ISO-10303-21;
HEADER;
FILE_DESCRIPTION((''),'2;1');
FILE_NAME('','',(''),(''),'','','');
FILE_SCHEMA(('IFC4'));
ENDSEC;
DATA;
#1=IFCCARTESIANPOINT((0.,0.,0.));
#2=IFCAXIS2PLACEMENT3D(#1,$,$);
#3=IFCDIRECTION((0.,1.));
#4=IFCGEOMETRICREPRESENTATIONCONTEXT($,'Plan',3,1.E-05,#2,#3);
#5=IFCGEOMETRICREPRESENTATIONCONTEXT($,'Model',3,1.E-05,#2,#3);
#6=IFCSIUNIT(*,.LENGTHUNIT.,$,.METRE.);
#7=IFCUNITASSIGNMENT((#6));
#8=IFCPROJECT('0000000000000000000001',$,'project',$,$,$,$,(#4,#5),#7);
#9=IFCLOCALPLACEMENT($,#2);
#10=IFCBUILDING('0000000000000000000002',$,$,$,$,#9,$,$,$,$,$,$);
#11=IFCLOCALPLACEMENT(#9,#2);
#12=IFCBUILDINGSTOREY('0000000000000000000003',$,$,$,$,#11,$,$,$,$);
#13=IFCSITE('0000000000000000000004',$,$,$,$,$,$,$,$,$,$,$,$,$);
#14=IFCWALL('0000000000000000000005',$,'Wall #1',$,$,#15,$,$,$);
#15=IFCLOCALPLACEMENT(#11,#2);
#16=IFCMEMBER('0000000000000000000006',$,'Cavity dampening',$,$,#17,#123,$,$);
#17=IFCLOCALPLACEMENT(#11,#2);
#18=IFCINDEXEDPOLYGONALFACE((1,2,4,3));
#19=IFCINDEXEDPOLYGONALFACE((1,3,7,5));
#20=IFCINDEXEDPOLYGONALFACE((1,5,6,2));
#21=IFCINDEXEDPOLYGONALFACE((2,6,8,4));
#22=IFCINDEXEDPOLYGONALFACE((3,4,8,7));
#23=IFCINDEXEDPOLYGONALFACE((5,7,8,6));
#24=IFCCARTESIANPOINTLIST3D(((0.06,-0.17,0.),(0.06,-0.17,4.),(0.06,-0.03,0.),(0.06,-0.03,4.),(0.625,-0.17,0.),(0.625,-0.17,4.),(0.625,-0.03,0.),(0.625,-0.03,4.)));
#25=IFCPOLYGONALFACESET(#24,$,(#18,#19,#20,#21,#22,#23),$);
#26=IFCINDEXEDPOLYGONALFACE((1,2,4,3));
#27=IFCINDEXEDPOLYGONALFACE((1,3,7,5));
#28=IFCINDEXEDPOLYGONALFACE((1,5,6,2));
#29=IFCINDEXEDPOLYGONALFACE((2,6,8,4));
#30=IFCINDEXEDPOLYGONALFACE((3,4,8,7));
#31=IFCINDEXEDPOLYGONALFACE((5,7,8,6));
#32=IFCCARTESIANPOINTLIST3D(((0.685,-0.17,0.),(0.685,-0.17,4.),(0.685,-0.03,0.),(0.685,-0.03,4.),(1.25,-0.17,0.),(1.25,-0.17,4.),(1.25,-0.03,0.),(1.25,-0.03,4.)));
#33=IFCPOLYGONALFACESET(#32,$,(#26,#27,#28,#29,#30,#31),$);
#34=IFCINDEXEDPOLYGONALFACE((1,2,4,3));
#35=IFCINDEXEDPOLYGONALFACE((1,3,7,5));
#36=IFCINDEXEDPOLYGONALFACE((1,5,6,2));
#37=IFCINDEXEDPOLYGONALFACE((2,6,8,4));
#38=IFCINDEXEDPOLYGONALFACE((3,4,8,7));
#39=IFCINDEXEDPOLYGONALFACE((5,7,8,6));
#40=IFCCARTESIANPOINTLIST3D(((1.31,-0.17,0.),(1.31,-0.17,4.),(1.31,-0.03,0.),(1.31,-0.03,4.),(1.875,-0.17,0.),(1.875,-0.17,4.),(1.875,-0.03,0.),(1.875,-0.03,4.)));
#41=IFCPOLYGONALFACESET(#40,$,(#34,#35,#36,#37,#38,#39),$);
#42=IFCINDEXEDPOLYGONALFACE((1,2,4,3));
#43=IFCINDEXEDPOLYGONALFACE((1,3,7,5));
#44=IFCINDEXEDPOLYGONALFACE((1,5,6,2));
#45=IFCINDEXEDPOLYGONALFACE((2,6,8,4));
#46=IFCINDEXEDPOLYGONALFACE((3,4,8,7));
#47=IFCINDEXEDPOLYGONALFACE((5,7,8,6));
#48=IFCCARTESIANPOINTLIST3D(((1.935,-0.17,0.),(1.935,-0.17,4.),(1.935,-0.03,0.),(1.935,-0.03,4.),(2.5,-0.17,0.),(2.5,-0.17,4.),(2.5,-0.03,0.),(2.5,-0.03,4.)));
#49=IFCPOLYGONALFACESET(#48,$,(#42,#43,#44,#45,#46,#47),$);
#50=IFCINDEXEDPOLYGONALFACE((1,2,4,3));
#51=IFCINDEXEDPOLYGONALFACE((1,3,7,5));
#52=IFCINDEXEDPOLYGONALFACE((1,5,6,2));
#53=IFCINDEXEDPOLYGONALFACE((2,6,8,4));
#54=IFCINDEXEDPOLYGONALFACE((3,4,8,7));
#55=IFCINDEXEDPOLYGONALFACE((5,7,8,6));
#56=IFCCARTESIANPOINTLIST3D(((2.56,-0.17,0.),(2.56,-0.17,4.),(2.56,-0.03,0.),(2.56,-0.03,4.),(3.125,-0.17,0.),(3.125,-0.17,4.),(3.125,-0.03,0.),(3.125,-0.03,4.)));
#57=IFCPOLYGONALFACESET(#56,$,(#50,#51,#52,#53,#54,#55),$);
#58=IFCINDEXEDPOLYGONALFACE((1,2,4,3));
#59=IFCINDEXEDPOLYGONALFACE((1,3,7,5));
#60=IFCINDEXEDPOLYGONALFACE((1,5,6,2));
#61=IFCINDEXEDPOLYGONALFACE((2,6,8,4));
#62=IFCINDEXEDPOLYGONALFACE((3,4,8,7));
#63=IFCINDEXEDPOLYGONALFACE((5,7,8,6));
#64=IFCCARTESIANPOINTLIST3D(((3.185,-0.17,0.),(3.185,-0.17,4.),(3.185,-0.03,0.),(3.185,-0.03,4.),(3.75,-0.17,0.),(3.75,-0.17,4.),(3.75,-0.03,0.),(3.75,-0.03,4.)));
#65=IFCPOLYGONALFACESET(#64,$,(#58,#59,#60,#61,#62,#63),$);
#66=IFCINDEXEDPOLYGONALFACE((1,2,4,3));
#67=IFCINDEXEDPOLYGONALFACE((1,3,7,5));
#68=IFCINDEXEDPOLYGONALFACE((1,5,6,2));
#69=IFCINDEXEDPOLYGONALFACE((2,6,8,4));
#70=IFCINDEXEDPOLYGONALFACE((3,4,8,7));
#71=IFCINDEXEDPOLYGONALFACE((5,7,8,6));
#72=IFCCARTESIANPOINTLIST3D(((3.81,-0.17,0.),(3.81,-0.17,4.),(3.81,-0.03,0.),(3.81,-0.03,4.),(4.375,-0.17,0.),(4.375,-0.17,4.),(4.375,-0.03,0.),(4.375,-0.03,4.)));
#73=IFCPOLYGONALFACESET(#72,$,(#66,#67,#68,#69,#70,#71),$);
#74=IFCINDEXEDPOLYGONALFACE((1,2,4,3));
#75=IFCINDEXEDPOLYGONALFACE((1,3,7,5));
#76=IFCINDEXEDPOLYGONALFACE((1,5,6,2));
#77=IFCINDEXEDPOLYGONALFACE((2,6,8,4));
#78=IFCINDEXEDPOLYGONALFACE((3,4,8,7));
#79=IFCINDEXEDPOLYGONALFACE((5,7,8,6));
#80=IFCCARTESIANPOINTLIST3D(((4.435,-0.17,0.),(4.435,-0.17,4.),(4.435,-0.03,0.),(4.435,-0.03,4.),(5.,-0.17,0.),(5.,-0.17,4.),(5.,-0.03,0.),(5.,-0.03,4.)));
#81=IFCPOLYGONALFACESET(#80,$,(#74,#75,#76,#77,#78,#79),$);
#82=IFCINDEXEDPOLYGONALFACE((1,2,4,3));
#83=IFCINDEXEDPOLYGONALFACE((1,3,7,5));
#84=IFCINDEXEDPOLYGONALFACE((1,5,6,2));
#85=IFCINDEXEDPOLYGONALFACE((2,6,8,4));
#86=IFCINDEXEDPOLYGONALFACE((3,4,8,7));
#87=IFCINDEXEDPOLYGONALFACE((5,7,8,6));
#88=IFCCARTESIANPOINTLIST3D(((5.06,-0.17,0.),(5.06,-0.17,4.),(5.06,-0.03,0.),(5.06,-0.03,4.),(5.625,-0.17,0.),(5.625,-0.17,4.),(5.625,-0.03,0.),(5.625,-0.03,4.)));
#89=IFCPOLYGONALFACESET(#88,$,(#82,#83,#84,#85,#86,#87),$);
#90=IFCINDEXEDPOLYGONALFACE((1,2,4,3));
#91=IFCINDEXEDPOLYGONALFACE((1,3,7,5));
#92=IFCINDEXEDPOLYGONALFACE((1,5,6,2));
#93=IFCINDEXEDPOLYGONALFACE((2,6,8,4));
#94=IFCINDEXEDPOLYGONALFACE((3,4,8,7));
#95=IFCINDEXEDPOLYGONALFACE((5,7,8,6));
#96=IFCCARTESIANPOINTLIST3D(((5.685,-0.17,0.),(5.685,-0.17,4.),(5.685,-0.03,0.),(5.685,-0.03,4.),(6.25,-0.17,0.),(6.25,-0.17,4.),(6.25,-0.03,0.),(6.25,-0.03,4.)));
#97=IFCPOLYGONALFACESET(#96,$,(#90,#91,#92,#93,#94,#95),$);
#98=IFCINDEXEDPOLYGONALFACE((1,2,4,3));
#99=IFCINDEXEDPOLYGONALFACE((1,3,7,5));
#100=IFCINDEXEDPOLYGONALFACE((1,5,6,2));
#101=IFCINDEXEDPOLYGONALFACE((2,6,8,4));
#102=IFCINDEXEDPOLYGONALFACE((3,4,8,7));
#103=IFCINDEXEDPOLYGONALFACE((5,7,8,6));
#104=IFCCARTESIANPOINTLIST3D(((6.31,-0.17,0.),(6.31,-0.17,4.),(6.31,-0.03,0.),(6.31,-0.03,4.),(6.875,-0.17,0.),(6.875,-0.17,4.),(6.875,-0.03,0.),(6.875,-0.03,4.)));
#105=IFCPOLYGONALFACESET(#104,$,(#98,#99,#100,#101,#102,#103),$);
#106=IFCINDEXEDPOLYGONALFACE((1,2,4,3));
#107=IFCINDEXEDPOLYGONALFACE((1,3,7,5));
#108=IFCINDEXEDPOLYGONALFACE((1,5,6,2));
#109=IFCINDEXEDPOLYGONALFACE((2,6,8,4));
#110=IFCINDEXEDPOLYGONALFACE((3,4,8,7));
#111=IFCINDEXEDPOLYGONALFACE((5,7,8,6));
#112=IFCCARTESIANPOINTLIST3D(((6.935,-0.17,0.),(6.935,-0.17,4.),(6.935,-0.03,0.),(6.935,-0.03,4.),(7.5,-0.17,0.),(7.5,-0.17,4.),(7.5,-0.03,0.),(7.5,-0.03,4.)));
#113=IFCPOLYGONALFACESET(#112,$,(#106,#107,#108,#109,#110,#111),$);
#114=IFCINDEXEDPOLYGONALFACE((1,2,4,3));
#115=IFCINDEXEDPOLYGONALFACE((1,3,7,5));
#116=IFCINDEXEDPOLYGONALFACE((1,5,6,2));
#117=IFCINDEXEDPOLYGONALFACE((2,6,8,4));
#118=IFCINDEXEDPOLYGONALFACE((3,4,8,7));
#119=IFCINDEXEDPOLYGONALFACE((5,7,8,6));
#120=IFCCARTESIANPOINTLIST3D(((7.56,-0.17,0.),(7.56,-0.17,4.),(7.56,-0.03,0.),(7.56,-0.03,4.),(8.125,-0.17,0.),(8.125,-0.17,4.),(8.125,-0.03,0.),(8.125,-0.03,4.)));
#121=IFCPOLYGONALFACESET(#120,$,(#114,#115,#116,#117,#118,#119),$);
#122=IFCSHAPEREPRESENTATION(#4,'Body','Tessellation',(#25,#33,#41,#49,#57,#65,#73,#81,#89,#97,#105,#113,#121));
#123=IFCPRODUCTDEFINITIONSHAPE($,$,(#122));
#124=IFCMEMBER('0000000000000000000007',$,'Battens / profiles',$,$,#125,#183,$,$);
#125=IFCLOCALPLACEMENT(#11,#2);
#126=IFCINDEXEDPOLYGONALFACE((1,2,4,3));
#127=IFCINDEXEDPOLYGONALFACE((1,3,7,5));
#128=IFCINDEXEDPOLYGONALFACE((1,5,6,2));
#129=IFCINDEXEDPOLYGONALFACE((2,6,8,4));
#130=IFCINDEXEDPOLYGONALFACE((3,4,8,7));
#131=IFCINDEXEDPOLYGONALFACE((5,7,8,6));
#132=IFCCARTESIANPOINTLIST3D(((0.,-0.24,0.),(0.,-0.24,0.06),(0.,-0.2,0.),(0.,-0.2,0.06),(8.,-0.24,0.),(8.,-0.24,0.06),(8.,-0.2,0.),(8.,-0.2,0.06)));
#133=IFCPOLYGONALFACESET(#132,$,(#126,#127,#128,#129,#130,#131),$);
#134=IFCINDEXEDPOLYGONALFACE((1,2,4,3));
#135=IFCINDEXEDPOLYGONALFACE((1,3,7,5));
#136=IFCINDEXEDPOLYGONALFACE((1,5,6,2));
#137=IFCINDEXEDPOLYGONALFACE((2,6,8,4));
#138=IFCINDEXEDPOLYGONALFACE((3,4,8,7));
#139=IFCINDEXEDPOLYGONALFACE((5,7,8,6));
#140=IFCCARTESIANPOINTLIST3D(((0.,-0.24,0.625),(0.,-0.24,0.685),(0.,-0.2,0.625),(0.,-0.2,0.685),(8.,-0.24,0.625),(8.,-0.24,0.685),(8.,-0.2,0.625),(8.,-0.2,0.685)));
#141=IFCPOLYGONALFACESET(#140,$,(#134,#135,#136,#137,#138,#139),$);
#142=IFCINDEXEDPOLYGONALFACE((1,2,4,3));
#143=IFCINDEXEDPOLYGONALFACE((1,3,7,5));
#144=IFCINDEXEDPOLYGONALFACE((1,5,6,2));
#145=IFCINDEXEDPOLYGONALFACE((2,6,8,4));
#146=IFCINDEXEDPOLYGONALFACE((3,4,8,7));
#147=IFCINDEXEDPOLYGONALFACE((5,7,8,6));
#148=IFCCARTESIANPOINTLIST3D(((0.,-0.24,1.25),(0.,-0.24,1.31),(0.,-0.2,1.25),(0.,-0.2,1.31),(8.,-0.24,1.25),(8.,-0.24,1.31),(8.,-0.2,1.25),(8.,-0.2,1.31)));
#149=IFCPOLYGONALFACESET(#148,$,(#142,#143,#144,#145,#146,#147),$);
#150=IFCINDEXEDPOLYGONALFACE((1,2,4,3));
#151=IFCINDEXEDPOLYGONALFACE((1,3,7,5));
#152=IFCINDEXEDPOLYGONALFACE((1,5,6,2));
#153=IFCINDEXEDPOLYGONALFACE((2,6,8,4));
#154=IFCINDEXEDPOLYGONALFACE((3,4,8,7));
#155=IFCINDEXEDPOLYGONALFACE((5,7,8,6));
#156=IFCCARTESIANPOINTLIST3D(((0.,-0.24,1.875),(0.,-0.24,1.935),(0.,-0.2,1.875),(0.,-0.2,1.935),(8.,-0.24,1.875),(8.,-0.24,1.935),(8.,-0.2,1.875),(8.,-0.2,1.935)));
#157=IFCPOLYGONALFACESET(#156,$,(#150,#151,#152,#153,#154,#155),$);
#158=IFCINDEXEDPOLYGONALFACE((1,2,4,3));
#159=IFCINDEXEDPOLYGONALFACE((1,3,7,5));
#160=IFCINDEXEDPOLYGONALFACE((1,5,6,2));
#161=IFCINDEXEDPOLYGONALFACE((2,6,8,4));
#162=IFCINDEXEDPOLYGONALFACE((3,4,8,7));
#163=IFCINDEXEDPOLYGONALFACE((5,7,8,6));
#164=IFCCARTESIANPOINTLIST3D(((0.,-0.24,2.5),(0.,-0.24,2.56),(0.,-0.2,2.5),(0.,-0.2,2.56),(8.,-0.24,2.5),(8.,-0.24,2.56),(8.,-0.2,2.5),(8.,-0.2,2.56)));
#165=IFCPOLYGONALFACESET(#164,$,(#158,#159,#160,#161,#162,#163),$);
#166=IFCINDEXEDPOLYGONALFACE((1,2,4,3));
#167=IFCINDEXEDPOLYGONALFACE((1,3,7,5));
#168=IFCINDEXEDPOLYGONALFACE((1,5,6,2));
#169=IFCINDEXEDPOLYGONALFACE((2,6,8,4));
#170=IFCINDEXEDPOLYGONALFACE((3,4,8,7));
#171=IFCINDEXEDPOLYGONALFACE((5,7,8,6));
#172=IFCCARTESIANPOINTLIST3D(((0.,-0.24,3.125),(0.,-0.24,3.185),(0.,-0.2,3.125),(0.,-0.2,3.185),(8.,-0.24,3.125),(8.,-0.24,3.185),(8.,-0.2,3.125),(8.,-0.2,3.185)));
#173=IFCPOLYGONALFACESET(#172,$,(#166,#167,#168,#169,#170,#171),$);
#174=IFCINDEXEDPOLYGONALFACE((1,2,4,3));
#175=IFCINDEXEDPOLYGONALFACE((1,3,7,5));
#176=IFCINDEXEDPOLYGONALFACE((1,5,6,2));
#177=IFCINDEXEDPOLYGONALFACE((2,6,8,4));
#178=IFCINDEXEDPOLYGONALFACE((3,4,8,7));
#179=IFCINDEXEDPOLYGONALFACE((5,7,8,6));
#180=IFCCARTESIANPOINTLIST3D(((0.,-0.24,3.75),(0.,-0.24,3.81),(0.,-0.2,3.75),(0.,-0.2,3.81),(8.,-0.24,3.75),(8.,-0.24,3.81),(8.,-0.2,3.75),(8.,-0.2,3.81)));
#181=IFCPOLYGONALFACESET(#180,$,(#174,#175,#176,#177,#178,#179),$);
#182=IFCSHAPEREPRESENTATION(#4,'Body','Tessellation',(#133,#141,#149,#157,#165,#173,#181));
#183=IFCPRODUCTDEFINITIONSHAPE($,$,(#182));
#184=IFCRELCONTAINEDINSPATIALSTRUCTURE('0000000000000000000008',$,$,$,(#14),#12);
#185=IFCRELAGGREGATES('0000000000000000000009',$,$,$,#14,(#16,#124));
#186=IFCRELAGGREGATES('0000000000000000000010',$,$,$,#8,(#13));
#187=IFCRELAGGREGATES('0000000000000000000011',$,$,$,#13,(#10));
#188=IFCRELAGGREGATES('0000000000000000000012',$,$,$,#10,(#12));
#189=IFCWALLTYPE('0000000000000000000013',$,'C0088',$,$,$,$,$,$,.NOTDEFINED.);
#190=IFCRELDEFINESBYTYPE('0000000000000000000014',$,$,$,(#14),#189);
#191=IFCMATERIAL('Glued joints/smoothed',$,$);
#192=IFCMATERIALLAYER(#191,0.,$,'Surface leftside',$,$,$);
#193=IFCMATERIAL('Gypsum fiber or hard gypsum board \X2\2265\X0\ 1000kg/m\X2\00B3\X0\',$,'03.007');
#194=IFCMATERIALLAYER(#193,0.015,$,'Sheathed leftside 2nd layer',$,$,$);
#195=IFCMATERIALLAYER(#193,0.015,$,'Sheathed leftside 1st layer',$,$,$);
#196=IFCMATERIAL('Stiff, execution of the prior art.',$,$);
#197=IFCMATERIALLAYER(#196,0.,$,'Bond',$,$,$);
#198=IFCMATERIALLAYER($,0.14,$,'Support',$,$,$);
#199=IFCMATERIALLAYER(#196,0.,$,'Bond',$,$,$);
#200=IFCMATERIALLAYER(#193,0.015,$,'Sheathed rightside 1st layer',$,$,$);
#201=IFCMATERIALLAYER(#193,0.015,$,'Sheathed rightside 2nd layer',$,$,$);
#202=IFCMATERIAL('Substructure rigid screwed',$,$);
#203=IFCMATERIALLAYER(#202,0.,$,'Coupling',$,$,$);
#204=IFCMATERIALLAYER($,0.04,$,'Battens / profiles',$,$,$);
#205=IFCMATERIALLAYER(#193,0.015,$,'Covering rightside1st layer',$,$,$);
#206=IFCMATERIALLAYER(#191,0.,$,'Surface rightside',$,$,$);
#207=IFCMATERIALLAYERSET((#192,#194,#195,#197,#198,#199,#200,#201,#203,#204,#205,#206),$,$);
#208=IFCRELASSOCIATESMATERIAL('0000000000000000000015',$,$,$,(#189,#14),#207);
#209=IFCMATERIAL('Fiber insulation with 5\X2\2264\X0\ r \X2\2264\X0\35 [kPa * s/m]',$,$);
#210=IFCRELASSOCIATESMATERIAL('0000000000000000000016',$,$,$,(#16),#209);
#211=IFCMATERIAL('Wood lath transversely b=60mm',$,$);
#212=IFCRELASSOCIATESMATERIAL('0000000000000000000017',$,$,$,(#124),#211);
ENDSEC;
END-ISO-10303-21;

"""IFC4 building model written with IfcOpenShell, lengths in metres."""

from ifc_helpers import new_model, si_unit, direction, frame, frame_2d, origin, place, context, project, spatial, rectangle, extrude, material, layer, layer_set, type_object, element, aggregate, save


model = new_model("IFC4")

# Units and contexts
plan_context = context("Plan", 3, precision=1e-05, world=origin(), true_north=direction((0.0, 1.0)))
model_context = context("Model", 3, precision=1e-05, world=origin(), true_north=direction((0.0, 1.0)))
ifc_project = project(units=[si_unit("LENGTHUNIT", "METRE")], contexts=[plan_context, model_context])

# Site, building, storey
site = spatial("IfcSite", under=ifc_project)
building_placement = place(None, origin())
building = spatial("IfcBuilding", under=site, at=building_placement)
storey_placement = place(building_placement, origin())
storey = spatial("IfcBuildingStorey", under=building, at=storey_placement)

# Wall, members
ifc_material_1 = material(Name="Glued joints/smoothed")
ifc_layer_1 = layer(ifc_material_1, 0.0, Name="Surface leftside")
ifc_material_2 = material(Name="Gypsum fiber or hard gypsum board ≥ 1000kg/m³", Category="03.007")
ifc_layer_2 = layer(ifc_material_2, 0.015, Name="Sheathed leftside 2nd layer")
ifc_layer_3 = layer(ifc_material_2, 0.015, Name="Sheathed leftside 1st layer")
ifc_material_3 = material(Name="Stiff, execution of the prior art.")
ifc_layer_4 = layer(ifc_material_3, 0.0, Name="Bond")
ifc_layer_5 = layer(None, 0.14, Name="Support")
ifc_layer_6 = layer(ifc_material_3, 0.0, Name="Bond")
ifc_layer_7 = layer(ifc_material_2, 0.015, Name="Sheathed rightside 1st layer")
ifc_layer_8 = layer(ifc_material_2, 0.015, Name="Sheathed rightside 2nd layer")
ifc_material_4 = material(Name="Substructure rigid screwed")
ifc_layer_9 = layer(ifc_material_4, 0.0, Name="Coupling")
ifc_layer_10 = layer(None, 0.04, Name="Battens / profiles")
ifc_layer_11 = layer(ifc_material_2, 0.015, Name="Covering rightside1st layer")
ifc_layer_12 = layer(ifc_material_1, 0.0, Name="Surface rightside")
ifc_layer_set = layer_set([ifc_layer_1, ifc_layer_2, ifc_layer_3, ifc_layer_4, ifc_layer_5, ifc_layer_6, ifc_layer_7, ifc_layer_8, ifc_layer_9, ifc_layer_10, ifc_layer_11, ifc_layer_12])
wall_type = type_object("IfcWallType", Name="C0088", PredefinedType="NOTDEFINED", material=ifc_layer_set)
wall_placement = place(None, frame((0.0, 0.0, 0.0), z_axis=(0.0, -1.0, 0.0), x_axis=(1.0, 0.0, 0.0)))
wall = element("IfcWall", 1, at=wall_placement, inside=storey, type_object=wall_type, material=ifc_layer_set, Name="Wall #1")
ifc_material_5 = material(Name="Fiber insulation with 5≤ r ≤35 [kPa * s/m]")
member_1_placement = place(wall_placement, origin())
member_1 = element("IfcMember", 2, at=member_1_placement, material=ifc_material_5, Name="Cavity dampening", context=plan_context, shape_type="SweptSolid", body=[
    extrude(rectangle(XDim=0.565, YDim=0.14, at=frame_2d((0.2825, 0.07), x_axis=(1.0, 0.0))), frame((0.06, 4.0, 0.03), z_axis=(0.0, -1.0, 0.0), x_axis=(1.0, 0.0, 0.0)), (0.0, 0.0, 1.0), 4.0),
    extrude(rectangle(XDim=0.565, YDim=0.14, at=frame_2d((0.2825, 0.07), x_axis=(1.0, 0.0))), frame((0.685, 4.0, 0.03), z_axis=(0.0, -1.0, 0.0), x_axis=(1.0, 0.0, 0.0)), (0.0, 0.0, 1.0), 4.0),
    extrude(rectangle(XDim=0.565, YDim=0.14, at=frame_2d((0.2825, 0.07), x_axis=(1.0, 0.0))), frame((1.31, 4.0, 0.03), z_axis=(0.0, -1.0, 0.0), x_axis=(1.0, 0.0, 0.0)), (0.0, 0.0, 1.0), 4.0),
    extrude(rectangle(XDim=0.565, YDim=0.14, at=frame_2d((0.2825, 0.07), x_axis=(1.0, 0.0))), frame((1.935, 4.0, 0.03), z_axis=(0.0, -1.0, 0.0), x_axis=(1.0, 0.0, 0.0)), (0.0, 0.0, 1.0), 4.0),
    extrude(rectangle(XDim=0.565, YDim=0.14, at=frame_2d((0.2825, 0.07), x_axis=(1.0, 0.0))), frame((2.56, 4.0, 0.03), z_axis=(0.0, -1.0, 0.0), x_axis=(1.0, 0.0, 0.0)), (0.0, 0.0, 1.0), 4.0),
    extrude(rectangle(XDim=0.565, YDim=0.14, at=frame_2d((0.2825, 0.07), x_axis=(1.0, 0.0))), frame((3.185, 4.0, 0.03), z_axis=(0.0, -1.0, 0.0), x_axis=(1.0, 0.0, 0.0)), (0.0, 0.0, 1.0), 4.0),
    extrude(rectangle(XDim=0.565, YDim=0.14, at=frame_2d((0.2825, 0.07), x_axis=(1.0, 0.0))), frame((3.81, 4.0, 0.03), z_axis=(0.0, -1.0, 0.0), x_axis=(1.0, 0.0, 0.0)), (0.0, 0.0, 1.0), 4.0),
    extrude(rectangle(XDim=0.565, YDim=0.14, at=frame_2d((0.2825, 0.07), x_axis=(1.0, 0.0))), frame((4.435, 4.0, 0.03), z_axis=(0.0, -1.0, 0.0), x_axis=(1.0, 0.0, 0.0)), (0.0, 0.0, 1.0), 4.0),
    extrude(rectangle(XDim=0.565, YDim=0.14, at=frame_2d((0.2825, 0.07), x_axis=(1.0, 0.0))), frame((5.06, 4.0, 0.03), z_axis=(0.0, -1.0, 0.0), x_axis=(1.0, 0.0, 0.0)), (0.0, 0.0, 1.0), 4.0),
    extrude(rectangle(XDim=0.565, YDim=0.14, at=frame_2d((0.2825, 0.07), x_axis=(1.0, 0.0))), frame((5.685, 4.0, 0.03), z_axis=(0.0, -1.0, 0.0), x_axis=(1.0, 0.0, 0.0)), (0.0, 0.0, 1.0), 4.0),
    extrude(rectangle(XDim=0.565, YDim=0.14, at=frame_2d((0.2825, 0.07), x_axis=(1.0, 0.0))), frame((6.31, 4.0, 0.03), z_axis=(0.0, -1.0, 0.0), x_axis=(1.0, 0.0, 0.0)), (0.0, 0.0, 1.0), 4.0),
    extrude(rectangle(XDim=0.565, YDim=0.14, at=frame_2d((0.2825, 0.07), x_axis=(1.0, 0.0))), frame((6.935, 4.0, 0.03), z_axis=(0.0, -1.0, 0.0), x_axis=(1.0, 0.0, 0.0)), (0.0, 0.0, 1.0), 4.0),
    extrude(rectangle(XDim=0.565, YDim=0.14, at=frame_2d((0.2825, 0.07), x_axis=(1.0, 0.0))), frame((7.56, 4.0, 0.03), z_axis=(0.0, -1.0, 0.0), x_axis=(1.0, 0.0, 0.0)), (0.0, 0.0, 1.0), 4.0),
])
ifc_material_6 = material(Name="Wood lath transversely b=60mm")
member_2_placement = place(wall_placement, origin())
member_2 = element("IfcMember", 3, at=member_2_placement, material=ifc_material_6, Name="Battens / profiles", context=plan_context, shape_type="SweptSolid", body=[
    extrude(rectangle(XDim=0.06, YDim=0.04, at=frame_2d((0.03, 0.02), x_axis=(1.0, 0.0))), frame((0.0, 0.0, 0.2), z_axis=(1.0, 0.0, 0.0), x_axis=(0.0, 1.0, 0.0)), (0.0, 0.0, 1.0), 8.0),
    extrude(rectangle(XDim=0.06, YDim=0.04, at=frame_2d((0.03, 0.02), x_axis=(1.0, 0.0))), frame((0.0, 0.625, 0.2), z_axis=(1.0, 0.0, 0.0), x_axis=(0.0, 1.0, 0.0)), (0.0, 0.0, 1.0), 8.0),
    extrude(rectangle(XDim=0.06, YDim=0.04, at=frame_2d((0.03, 0.02), x_axis=(1.0, 0.0))), frame((0.0, 1.25, 0.2), z_axis=(1.0, 0.0, 0.0), x_axis=(0.0, 1.0, 0.0)), (0.0, 0.0, 1.0), 8.0),
    extrude(rectangle(XDim=0.06, YDim=0.04, at=frame_2d((0.03, 0.02), x_axis=(1.0, 0.0))), frame((0.0, 1.875, 0.2), z_axis=(1.0, 0.0, 0.0), x_axis=(0.0, 1.0, 0.0)), (0.0, 0.0, 1.0), 8.0),
    extrude(rectangle(XDim=0.06, YDim=0.04, at=frame_2d((0.03, 0.02), x_axis=(1.0, 0.0))), frame((0.0, 2.5, 0.2), z_axis=(1.0, 0.0, 0.0), x_axis=(0.0, 1.0, 0.0)), (0.0, 0.0, 1.0), 8.0),
    extrude(rectangle(XDim=0.06, YDim=0.04, at=frame_2d((0.03, 0.02), x_axis=(1.0, 0.0))), frame((0.0, 3.125, 0.2), z_axis=(1.0, 0.0, 0.0), x_axis=(0.0, 1.0, 0.0)), (0.0, 0.0, 1.0), 8.0),
    extrude(rectangle(XDim=0.06, YDim=0.04, at=frame_2d((0.03, 0.02), x_axis=(1.0, 0.0))), frame((0.0, 3.75, 0.2), z_axis=(1.0, 0.0, 0.0), x_axis=(0.0, 1.0, 0.0)), (0.0, 0.0, 1.0), 8.0),
])
aggregate(wall, [member_1, member_2])

save(model, "model.ifc")
